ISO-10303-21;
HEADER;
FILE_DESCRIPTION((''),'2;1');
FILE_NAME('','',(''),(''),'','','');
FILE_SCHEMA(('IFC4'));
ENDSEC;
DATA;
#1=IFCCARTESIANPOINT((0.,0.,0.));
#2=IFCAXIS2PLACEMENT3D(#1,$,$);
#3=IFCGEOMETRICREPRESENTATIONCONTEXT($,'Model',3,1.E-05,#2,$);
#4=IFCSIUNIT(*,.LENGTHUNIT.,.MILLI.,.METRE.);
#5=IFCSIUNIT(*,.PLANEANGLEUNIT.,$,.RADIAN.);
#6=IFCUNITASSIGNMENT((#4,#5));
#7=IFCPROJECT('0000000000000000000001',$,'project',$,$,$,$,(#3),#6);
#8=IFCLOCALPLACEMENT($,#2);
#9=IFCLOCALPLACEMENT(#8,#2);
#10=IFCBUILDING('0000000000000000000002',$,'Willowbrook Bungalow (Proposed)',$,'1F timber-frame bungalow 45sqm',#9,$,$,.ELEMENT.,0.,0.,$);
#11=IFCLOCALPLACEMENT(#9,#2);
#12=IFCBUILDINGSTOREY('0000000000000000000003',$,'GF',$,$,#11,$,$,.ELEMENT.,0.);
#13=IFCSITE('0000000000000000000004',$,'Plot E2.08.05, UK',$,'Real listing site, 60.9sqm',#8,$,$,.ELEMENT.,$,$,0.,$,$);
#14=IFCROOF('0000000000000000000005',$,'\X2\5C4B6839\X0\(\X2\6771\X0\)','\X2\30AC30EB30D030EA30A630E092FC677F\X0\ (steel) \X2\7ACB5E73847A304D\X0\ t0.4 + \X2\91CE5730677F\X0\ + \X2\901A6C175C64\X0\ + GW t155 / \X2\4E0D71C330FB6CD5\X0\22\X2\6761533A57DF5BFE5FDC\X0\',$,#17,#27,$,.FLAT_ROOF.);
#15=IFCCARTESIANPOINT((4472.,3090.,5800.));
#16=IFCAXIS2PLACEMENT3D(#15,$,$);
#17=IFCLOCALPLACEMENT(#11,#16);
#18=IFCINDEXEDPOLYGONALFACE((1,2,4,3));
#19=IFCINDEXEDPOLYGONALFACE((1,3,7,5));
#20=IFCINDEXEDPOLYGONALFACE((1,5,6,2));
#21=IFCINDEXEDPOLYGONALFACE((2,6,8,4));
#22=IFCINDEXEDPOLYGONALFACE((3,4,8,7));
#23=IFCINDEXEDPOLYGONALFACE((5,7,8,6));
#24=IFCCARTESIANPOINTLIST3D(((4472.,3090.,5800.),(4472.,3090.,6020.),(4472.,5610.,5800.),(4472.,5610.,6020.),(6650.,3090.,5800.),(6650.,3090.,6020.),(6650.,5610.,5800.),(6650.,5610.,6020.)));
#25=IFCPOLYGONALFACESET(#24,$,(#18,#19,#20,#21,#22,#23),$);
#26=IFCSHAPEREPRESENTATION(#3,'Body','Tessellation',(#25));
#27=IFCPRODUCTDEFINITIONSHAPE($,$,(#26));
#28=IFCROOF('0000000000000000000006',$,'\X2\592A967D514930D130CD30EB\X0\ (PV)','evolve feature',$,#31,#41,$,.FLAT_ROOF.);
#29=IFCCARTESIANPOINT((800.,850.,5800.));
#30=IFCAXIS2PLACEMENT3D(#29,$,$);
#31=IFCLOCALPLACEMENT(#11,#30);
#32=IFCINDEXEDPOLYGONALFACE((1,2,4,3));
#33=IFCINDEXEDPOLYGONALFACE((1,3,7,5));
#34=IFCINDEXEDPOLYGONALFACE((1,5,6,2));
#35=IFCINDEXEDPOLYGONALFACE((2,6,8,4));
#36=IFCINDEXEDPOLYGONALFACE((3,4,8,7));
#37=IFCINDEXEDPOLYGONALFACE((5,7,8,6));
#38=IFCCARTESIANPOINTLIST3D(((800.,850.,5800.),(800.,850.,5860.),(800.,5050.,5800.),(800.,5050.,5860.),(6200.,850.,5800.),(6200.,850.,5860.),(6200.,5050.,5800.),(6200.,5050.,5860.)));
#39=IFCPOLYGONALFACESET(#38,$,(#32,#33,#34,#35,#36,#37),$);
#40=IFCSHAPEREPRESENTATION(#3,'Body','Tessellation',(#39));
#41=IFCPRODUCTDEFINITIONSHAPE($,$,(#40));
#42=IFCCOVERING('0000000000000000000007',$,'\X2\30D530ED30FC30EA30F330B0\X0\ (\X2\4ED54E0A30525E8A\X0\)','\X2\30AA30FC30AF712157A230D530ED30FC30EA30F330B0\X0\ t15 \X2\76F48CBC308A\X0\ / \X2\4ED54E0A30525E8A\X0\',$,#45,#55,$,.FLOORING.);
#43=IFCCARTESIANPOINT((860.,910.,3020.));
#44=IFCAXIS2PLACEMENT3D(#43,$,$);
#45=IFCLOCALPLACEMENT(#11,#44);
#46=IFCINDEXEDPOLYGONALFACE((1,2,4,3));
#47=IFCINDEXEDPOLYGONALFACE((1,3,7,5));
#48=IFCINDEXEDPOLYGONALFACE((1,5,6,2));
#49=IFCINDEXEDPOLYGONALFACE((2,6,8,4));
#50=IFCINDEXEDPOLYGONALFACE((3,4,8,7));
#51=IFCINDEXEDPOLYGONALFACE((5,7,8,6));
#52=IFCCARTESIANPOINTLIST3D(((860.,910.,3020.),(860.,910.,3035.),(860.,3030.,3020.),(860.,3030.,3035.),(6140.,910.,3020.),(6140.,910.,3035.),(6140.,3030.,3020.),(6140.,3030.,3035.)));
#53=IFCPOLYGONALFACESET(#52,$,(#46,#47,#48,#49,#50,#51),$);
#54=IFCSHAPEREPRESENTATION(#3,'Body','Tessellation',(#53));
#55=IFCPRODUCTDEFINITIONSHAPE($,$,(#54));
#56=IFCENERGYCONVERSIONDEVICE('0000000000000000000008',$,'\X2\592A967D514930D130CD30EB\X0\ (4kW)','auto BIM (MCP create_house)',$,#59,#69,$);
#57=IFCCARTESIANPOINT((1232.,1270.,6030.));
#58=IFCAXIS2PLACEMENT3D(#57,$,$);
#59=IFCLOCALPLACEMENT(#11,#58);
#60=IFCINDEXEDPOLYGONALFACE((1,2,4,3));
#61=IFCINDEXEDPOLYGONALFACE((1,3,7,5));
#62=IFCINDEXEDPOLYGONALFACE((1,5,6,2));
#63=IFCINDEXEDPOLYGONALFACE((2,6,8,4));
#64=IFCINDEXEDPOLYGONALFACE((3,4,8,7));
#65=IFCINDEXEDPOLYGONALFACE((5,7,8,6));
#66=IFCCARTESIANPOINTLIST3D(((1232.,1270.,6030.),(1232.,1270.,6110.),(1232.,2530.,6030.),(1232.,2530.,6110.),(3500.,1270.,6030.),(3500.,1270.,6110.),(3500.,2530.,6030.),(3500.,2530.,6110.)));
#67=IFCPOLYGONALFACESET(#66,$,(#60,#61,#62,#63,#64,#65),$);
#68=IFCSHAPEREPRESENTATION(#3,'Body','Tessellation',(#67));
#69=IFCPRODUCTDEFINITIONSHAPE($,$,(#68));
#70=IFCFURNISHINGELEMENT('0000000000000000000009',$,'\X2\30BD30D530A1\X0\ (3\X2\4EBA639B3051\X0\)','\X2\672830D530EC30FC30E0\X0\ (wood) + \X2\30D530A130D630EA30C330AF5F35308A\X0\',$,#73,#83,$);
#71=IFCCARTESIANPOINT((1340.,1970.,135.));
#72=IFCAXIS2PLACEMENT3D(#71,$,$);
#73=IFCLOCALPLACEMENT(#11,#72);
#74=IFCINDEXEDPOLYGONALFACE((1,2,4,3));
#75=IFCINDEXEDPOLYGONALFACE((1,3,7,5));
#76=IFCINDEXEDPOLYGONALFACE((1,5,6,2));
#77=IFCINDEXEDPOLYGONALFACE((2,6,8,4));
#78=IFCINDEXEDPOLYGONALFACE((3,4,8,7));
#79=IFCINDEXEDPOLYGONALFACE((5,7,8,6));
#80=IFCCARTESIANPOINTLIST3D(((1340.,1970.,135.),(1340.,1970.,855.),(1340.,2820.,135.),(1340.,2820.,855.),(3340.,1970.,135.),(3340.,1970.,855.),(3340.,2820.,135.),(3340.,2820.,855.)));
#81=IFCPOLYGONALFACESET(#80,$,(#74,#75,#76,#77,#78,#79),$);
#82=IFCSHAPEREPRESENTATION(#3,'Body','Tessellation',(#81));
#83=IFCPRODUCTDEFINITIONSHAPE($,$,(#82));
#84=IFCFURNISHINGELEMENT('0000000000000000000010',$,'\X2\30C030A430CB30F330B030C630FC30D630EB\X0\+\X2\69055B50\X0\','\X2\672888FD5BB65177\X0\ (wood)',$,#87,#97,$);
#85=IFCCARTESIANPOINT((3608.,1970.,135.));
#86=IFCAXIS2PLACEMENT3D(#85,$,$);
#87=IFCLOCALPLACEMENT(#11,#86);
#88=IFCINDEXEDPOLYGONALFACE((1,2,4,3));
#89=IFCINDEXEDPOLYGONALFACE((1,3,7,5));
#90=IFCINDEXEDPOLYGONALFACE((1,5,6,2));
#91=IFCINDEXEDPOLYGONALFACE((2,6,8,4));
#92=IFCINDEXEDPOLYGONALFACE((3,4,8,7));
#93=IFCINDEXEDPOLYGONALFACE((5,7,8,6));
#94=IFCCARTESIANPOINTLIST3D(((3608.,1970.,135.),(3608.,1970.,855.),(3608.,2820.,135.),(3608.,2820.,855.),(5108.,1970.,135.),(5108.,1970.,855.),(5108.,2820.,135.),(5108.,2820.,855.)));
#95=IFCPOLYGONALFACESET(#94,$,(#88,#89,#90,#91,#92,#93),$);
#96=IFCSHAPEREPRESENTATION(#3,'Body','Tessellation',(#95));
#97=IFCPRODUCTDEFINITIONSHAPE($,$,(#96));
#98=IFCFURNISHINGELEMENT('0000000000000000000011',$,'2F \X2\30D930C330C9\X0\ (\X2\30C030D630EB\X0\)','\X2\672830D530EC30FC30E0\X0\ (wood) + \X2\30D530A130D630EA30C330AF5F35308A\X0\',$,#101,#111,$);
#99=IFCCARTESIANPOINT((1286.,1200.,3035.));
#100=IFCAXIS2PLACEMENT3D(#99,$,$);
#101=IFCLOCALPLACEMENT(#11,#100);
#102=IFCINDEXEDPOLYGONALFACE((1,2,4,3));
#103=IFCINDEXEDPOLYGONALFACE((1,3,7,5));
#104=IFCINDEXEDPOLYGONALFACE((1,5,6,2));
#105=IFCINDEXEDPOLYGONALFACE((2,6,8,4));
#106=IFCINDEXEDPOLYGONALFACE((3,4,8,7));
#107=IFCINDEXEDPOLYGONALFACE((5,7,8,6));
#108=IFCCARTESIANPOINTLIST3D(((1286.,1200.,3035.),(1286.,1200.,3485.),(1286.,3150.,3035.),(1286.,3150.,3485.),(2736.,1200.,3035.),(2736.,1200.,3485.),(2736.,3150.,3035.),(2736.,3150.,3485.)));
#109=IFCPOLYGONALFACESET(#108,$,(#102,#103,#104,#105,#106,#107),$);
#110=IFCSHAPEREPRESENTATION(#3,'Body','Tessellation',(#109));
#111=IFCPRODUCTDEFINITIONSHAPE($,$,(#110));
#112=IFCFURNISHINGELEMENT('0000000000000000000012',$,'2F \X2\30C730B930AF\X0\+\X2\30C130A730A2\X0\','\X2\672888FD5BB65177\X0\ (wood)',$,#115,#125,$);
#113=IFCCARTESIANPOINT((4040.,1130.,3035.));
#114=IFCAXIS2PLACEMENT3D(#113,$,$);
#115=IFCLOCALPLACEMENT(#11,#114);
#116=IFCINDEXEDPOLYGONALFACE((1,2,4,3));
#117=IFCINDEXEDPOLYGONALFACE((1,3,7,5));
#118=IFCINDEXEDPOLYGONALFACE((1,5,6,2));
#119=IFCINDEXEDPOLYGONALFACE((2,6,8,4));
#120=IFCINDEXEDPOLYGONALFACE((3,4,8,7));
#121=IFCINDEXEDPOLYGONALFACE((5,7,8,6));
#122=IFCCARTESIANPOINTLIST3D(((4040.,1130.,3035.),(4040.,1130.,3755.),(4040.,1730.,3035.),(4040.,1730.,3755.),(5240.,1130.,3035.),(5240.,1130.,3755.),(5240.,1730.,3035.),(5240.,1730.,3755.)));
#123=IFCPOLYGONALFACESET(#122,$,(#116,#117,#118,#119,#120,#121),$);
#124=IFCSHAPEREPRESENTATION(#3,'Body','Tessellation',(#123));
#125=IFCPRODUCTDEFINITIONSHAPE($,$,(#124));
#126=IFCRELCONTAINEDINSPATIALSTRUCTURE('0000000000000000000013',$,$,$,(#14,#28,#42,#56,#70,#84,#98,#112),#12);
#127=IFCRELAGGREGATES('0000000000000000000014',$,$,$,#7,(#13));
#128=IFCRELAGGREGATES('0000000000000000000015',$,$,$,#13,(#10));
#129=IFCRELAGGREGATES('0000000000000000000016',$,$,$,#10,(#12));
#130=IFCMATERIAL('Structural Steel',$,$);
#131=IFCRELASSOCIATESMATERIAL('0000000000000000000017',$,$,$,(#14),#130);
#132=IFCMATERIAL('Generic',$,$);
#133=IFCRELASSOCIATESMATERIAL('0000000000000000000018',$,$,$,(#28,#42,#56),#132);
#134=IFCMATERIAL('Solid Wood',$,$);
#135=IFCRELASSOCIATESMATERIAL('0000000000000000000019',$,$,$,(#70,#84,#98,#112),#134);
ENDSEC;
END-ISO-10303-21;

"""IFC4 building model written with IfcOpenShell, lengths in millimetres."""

from ifc_helpers import new_model, si_unit, frame, frame_2d, origin, place, context, project, spatial, rectangle, extrude, material, element, save


model = new_model("IFC4")

# Units and contexts
model_context = context("Model", 3, precision=1e-05, world=origin())
ifc_project = project(units=[si_unit("LENGTHUNIT", "METRE", prefix="MILLI"), si_unit("PLANEANGLEUNIT", "RADIAN")], contexts=[model_context])

# Site, building, storey
site_placement = place(None, origin())
site = spatial("IfcSite", under=ifc_project, at=site_placement, Name="Plot E2.08.05, UK", ObjectType="Real listing site, 60.9sqm", CompositionType="ELEMENT", RefElevation=0.0)
building_placement = place(site_placement, origin())
building = spatial("IfcBuilding", under=site, at=building_placement, Name="Willowbrook Bungalow (Proposed)", ObjectType="1F timber-frame bungalow 45sqm", CompositionType="ELEMENT", ElevationOfRefHeight=0.0, ElevationOfTerrain=0.0)
storey_placement = place(building_placement, origin())
storey = spatial("IfcBuildingStorey", under=building, at=storey_placement, Name="GF", CompositionType="ELEMENT", Elevation=0.0)

# Shared definitions
ifc_material_1 = material(Name="Solid Wood")

# Roofs
ifc_material_2 = material(Name="Structural Steel")
roof_1_placement = place(storey_placement, frame((4472.0, 3090.0, 5800.0)))
element("IfcRoof", 1, at=roof_1_placement, inside=storey, material=ifc_material_2, Name="屋根(東)", Description="ガルバリウム鋼板 (steel) 立平葺き t0.4 + 野地板 + 通気層 + GW t155 / 不燃・法22条区域対応", PredefinedType="FLAT_ROOF", context=model_context, shape_type="SweptSolid", body=[
    extrude(rectangle(XDim=2178.0, YDim=2520.0, at=frame_2d((1089.0, 1260.0))), frame((4472.0, 3090.0, 5800.0)), (0.0, 0.0, 1.0), 220.0),
])
ifc_material_3 = material(Name="Generic")
roof_2_placement = place(storey_placement, frame((800.0, 850.0, 5800.0)))
element("IfcRoof", 2, at=roof_2_placement, inside=storey, material=ifc_material_3, Name="太陽光パネル (PV)", Description="evolve feature", PredefinedType="FLAT_ROOF", context=model_context, shape_type="SweptSolid", body=[
    extrude(rectangle(XDim=5400.0, YDim=4200.0, at=frame_2d((2700.0, 2100.0))), frame((800.0, 850.0, 5800.0)), (0.0, 0.0, 1.0), 60.0),
])

# Covering
covering_placement = place(storey_placement, frame((860.0, 910.0, 3020.0)))
element("IfcCovering", 3, at=covering_placement, inside=storey, material=ifc_material_3, Name="フローリング (仕上げ床)", Description="オーク無垢フローリング t15 直貼り / 仕上げ床", PredefinedType="FLOORING", context=model_context, shape_type="SweptSolid", body=[
    extrude(rectangle(XDim=5280.0, YDim=2120.0, at=frame_2d((2640.0, 1060.0))), frame((860.0, 910.0, 3020.0)), (0.0, 0.0, 1.0), 15.0),
])

# Energy conversion device
energy_conversion_device_placement = place(storey_placement, frame((1232.0, 1270.0, 6030.0)))
element("IfcEnergyConversionDevice", 4, at=energy_conversion_device_placement, inside=storey, material=ifc_material_3, Name="太陽光パネル (4kW)", Description="auto BIM (MCP create_house)", context=model_context, shape_type="SweptSolid", body=[
    extrude(rectangle(XDim=2268.0, YDim=1260.0, at=frame_2d((1134.0, 630.0))), frame((1232.0, 1270.0, 6030.0)), (0.0, 0.0, 1.0), 80.0),
])

# Furnishing elements
furnishing_1_placement = place(storey_placement, frame((1340.0, 1970.0, 135.0)))
element("IfcFurnishingElement", 5, at=furnishing_1_placement, inside=storey, material=ifc_material_1, Name="ソファ (3人掛け)", Description="木フレーム (wood) + ファブリック張り", context=model_context, shape_type="SweptSolid", body=[
    extrude(rectangle(XDim=2000.0, YDim=850.0, at=frame_2d((1000.0, 425.0))), frame((1340.0, 1970.0, 135.0)), (0.0, 0.0, 1.0), 720.0),
])
furnishing_2_placement = place(storey_placement, frame((3608.0, 1970.0, 135.0)))
element("IfcFurnishingElement", 6, at=furnishing_2_placement, inside=storey, material=ifc_material_1, Name="ダイニングテーブル+椅子", Description="木製家具 (wood)", context=model_context, shape_type="SweptSolid", body=[
    extrude(rectangle(XDim=1500.0, YDim=850.0, at=frame_2d((750.0, 425.0))), frame((3608.0, 1970.0, 135.0)), (0.0, 0.0, 1.0), 720.0),
])
furnishing_3_placement = place(storey_placement, frame((1286.0, 1200.0, 3035.0)))
element("IfcFurnishingElement", 7, at=furnishing_3_placement, inside=storey, material=ifc_material_1, Name="2F ベッド (ダブル)", Description="木フレーム (wood) + ファブリック張り", context=model_context, shape_type="SweptSolid", body=[
    extrude(rectangle(XDim=1450.0, YDim=1950.0, at=frame_2d((725.0, 975.0))), frame((1286.0, 1200.0, 3035.0)), (0.0, 0.0, 1.0), 450.0),
])
furnishing_4_placement = place(storey_placement, frame((4040.0, 1130.0, 3035.0)))
element("IfcFurnishingElement", 8, at=furnishing_4_placement, inside=storey, material=ifc_material_1, Name="2F デスク+チェア", Description="木製家具 (wood)", context=model_context, shape_type="SweptSolid", body=[
    extrude(rectangle(XDim=1200.0, YDim=600.0, at=frame_2d((600.0, 300.0))), frame((4040.0, 1130.0, 3035.0)), (0.0, 0.0, 1.0), 720.0),
])

save(model, "model.ifc")
